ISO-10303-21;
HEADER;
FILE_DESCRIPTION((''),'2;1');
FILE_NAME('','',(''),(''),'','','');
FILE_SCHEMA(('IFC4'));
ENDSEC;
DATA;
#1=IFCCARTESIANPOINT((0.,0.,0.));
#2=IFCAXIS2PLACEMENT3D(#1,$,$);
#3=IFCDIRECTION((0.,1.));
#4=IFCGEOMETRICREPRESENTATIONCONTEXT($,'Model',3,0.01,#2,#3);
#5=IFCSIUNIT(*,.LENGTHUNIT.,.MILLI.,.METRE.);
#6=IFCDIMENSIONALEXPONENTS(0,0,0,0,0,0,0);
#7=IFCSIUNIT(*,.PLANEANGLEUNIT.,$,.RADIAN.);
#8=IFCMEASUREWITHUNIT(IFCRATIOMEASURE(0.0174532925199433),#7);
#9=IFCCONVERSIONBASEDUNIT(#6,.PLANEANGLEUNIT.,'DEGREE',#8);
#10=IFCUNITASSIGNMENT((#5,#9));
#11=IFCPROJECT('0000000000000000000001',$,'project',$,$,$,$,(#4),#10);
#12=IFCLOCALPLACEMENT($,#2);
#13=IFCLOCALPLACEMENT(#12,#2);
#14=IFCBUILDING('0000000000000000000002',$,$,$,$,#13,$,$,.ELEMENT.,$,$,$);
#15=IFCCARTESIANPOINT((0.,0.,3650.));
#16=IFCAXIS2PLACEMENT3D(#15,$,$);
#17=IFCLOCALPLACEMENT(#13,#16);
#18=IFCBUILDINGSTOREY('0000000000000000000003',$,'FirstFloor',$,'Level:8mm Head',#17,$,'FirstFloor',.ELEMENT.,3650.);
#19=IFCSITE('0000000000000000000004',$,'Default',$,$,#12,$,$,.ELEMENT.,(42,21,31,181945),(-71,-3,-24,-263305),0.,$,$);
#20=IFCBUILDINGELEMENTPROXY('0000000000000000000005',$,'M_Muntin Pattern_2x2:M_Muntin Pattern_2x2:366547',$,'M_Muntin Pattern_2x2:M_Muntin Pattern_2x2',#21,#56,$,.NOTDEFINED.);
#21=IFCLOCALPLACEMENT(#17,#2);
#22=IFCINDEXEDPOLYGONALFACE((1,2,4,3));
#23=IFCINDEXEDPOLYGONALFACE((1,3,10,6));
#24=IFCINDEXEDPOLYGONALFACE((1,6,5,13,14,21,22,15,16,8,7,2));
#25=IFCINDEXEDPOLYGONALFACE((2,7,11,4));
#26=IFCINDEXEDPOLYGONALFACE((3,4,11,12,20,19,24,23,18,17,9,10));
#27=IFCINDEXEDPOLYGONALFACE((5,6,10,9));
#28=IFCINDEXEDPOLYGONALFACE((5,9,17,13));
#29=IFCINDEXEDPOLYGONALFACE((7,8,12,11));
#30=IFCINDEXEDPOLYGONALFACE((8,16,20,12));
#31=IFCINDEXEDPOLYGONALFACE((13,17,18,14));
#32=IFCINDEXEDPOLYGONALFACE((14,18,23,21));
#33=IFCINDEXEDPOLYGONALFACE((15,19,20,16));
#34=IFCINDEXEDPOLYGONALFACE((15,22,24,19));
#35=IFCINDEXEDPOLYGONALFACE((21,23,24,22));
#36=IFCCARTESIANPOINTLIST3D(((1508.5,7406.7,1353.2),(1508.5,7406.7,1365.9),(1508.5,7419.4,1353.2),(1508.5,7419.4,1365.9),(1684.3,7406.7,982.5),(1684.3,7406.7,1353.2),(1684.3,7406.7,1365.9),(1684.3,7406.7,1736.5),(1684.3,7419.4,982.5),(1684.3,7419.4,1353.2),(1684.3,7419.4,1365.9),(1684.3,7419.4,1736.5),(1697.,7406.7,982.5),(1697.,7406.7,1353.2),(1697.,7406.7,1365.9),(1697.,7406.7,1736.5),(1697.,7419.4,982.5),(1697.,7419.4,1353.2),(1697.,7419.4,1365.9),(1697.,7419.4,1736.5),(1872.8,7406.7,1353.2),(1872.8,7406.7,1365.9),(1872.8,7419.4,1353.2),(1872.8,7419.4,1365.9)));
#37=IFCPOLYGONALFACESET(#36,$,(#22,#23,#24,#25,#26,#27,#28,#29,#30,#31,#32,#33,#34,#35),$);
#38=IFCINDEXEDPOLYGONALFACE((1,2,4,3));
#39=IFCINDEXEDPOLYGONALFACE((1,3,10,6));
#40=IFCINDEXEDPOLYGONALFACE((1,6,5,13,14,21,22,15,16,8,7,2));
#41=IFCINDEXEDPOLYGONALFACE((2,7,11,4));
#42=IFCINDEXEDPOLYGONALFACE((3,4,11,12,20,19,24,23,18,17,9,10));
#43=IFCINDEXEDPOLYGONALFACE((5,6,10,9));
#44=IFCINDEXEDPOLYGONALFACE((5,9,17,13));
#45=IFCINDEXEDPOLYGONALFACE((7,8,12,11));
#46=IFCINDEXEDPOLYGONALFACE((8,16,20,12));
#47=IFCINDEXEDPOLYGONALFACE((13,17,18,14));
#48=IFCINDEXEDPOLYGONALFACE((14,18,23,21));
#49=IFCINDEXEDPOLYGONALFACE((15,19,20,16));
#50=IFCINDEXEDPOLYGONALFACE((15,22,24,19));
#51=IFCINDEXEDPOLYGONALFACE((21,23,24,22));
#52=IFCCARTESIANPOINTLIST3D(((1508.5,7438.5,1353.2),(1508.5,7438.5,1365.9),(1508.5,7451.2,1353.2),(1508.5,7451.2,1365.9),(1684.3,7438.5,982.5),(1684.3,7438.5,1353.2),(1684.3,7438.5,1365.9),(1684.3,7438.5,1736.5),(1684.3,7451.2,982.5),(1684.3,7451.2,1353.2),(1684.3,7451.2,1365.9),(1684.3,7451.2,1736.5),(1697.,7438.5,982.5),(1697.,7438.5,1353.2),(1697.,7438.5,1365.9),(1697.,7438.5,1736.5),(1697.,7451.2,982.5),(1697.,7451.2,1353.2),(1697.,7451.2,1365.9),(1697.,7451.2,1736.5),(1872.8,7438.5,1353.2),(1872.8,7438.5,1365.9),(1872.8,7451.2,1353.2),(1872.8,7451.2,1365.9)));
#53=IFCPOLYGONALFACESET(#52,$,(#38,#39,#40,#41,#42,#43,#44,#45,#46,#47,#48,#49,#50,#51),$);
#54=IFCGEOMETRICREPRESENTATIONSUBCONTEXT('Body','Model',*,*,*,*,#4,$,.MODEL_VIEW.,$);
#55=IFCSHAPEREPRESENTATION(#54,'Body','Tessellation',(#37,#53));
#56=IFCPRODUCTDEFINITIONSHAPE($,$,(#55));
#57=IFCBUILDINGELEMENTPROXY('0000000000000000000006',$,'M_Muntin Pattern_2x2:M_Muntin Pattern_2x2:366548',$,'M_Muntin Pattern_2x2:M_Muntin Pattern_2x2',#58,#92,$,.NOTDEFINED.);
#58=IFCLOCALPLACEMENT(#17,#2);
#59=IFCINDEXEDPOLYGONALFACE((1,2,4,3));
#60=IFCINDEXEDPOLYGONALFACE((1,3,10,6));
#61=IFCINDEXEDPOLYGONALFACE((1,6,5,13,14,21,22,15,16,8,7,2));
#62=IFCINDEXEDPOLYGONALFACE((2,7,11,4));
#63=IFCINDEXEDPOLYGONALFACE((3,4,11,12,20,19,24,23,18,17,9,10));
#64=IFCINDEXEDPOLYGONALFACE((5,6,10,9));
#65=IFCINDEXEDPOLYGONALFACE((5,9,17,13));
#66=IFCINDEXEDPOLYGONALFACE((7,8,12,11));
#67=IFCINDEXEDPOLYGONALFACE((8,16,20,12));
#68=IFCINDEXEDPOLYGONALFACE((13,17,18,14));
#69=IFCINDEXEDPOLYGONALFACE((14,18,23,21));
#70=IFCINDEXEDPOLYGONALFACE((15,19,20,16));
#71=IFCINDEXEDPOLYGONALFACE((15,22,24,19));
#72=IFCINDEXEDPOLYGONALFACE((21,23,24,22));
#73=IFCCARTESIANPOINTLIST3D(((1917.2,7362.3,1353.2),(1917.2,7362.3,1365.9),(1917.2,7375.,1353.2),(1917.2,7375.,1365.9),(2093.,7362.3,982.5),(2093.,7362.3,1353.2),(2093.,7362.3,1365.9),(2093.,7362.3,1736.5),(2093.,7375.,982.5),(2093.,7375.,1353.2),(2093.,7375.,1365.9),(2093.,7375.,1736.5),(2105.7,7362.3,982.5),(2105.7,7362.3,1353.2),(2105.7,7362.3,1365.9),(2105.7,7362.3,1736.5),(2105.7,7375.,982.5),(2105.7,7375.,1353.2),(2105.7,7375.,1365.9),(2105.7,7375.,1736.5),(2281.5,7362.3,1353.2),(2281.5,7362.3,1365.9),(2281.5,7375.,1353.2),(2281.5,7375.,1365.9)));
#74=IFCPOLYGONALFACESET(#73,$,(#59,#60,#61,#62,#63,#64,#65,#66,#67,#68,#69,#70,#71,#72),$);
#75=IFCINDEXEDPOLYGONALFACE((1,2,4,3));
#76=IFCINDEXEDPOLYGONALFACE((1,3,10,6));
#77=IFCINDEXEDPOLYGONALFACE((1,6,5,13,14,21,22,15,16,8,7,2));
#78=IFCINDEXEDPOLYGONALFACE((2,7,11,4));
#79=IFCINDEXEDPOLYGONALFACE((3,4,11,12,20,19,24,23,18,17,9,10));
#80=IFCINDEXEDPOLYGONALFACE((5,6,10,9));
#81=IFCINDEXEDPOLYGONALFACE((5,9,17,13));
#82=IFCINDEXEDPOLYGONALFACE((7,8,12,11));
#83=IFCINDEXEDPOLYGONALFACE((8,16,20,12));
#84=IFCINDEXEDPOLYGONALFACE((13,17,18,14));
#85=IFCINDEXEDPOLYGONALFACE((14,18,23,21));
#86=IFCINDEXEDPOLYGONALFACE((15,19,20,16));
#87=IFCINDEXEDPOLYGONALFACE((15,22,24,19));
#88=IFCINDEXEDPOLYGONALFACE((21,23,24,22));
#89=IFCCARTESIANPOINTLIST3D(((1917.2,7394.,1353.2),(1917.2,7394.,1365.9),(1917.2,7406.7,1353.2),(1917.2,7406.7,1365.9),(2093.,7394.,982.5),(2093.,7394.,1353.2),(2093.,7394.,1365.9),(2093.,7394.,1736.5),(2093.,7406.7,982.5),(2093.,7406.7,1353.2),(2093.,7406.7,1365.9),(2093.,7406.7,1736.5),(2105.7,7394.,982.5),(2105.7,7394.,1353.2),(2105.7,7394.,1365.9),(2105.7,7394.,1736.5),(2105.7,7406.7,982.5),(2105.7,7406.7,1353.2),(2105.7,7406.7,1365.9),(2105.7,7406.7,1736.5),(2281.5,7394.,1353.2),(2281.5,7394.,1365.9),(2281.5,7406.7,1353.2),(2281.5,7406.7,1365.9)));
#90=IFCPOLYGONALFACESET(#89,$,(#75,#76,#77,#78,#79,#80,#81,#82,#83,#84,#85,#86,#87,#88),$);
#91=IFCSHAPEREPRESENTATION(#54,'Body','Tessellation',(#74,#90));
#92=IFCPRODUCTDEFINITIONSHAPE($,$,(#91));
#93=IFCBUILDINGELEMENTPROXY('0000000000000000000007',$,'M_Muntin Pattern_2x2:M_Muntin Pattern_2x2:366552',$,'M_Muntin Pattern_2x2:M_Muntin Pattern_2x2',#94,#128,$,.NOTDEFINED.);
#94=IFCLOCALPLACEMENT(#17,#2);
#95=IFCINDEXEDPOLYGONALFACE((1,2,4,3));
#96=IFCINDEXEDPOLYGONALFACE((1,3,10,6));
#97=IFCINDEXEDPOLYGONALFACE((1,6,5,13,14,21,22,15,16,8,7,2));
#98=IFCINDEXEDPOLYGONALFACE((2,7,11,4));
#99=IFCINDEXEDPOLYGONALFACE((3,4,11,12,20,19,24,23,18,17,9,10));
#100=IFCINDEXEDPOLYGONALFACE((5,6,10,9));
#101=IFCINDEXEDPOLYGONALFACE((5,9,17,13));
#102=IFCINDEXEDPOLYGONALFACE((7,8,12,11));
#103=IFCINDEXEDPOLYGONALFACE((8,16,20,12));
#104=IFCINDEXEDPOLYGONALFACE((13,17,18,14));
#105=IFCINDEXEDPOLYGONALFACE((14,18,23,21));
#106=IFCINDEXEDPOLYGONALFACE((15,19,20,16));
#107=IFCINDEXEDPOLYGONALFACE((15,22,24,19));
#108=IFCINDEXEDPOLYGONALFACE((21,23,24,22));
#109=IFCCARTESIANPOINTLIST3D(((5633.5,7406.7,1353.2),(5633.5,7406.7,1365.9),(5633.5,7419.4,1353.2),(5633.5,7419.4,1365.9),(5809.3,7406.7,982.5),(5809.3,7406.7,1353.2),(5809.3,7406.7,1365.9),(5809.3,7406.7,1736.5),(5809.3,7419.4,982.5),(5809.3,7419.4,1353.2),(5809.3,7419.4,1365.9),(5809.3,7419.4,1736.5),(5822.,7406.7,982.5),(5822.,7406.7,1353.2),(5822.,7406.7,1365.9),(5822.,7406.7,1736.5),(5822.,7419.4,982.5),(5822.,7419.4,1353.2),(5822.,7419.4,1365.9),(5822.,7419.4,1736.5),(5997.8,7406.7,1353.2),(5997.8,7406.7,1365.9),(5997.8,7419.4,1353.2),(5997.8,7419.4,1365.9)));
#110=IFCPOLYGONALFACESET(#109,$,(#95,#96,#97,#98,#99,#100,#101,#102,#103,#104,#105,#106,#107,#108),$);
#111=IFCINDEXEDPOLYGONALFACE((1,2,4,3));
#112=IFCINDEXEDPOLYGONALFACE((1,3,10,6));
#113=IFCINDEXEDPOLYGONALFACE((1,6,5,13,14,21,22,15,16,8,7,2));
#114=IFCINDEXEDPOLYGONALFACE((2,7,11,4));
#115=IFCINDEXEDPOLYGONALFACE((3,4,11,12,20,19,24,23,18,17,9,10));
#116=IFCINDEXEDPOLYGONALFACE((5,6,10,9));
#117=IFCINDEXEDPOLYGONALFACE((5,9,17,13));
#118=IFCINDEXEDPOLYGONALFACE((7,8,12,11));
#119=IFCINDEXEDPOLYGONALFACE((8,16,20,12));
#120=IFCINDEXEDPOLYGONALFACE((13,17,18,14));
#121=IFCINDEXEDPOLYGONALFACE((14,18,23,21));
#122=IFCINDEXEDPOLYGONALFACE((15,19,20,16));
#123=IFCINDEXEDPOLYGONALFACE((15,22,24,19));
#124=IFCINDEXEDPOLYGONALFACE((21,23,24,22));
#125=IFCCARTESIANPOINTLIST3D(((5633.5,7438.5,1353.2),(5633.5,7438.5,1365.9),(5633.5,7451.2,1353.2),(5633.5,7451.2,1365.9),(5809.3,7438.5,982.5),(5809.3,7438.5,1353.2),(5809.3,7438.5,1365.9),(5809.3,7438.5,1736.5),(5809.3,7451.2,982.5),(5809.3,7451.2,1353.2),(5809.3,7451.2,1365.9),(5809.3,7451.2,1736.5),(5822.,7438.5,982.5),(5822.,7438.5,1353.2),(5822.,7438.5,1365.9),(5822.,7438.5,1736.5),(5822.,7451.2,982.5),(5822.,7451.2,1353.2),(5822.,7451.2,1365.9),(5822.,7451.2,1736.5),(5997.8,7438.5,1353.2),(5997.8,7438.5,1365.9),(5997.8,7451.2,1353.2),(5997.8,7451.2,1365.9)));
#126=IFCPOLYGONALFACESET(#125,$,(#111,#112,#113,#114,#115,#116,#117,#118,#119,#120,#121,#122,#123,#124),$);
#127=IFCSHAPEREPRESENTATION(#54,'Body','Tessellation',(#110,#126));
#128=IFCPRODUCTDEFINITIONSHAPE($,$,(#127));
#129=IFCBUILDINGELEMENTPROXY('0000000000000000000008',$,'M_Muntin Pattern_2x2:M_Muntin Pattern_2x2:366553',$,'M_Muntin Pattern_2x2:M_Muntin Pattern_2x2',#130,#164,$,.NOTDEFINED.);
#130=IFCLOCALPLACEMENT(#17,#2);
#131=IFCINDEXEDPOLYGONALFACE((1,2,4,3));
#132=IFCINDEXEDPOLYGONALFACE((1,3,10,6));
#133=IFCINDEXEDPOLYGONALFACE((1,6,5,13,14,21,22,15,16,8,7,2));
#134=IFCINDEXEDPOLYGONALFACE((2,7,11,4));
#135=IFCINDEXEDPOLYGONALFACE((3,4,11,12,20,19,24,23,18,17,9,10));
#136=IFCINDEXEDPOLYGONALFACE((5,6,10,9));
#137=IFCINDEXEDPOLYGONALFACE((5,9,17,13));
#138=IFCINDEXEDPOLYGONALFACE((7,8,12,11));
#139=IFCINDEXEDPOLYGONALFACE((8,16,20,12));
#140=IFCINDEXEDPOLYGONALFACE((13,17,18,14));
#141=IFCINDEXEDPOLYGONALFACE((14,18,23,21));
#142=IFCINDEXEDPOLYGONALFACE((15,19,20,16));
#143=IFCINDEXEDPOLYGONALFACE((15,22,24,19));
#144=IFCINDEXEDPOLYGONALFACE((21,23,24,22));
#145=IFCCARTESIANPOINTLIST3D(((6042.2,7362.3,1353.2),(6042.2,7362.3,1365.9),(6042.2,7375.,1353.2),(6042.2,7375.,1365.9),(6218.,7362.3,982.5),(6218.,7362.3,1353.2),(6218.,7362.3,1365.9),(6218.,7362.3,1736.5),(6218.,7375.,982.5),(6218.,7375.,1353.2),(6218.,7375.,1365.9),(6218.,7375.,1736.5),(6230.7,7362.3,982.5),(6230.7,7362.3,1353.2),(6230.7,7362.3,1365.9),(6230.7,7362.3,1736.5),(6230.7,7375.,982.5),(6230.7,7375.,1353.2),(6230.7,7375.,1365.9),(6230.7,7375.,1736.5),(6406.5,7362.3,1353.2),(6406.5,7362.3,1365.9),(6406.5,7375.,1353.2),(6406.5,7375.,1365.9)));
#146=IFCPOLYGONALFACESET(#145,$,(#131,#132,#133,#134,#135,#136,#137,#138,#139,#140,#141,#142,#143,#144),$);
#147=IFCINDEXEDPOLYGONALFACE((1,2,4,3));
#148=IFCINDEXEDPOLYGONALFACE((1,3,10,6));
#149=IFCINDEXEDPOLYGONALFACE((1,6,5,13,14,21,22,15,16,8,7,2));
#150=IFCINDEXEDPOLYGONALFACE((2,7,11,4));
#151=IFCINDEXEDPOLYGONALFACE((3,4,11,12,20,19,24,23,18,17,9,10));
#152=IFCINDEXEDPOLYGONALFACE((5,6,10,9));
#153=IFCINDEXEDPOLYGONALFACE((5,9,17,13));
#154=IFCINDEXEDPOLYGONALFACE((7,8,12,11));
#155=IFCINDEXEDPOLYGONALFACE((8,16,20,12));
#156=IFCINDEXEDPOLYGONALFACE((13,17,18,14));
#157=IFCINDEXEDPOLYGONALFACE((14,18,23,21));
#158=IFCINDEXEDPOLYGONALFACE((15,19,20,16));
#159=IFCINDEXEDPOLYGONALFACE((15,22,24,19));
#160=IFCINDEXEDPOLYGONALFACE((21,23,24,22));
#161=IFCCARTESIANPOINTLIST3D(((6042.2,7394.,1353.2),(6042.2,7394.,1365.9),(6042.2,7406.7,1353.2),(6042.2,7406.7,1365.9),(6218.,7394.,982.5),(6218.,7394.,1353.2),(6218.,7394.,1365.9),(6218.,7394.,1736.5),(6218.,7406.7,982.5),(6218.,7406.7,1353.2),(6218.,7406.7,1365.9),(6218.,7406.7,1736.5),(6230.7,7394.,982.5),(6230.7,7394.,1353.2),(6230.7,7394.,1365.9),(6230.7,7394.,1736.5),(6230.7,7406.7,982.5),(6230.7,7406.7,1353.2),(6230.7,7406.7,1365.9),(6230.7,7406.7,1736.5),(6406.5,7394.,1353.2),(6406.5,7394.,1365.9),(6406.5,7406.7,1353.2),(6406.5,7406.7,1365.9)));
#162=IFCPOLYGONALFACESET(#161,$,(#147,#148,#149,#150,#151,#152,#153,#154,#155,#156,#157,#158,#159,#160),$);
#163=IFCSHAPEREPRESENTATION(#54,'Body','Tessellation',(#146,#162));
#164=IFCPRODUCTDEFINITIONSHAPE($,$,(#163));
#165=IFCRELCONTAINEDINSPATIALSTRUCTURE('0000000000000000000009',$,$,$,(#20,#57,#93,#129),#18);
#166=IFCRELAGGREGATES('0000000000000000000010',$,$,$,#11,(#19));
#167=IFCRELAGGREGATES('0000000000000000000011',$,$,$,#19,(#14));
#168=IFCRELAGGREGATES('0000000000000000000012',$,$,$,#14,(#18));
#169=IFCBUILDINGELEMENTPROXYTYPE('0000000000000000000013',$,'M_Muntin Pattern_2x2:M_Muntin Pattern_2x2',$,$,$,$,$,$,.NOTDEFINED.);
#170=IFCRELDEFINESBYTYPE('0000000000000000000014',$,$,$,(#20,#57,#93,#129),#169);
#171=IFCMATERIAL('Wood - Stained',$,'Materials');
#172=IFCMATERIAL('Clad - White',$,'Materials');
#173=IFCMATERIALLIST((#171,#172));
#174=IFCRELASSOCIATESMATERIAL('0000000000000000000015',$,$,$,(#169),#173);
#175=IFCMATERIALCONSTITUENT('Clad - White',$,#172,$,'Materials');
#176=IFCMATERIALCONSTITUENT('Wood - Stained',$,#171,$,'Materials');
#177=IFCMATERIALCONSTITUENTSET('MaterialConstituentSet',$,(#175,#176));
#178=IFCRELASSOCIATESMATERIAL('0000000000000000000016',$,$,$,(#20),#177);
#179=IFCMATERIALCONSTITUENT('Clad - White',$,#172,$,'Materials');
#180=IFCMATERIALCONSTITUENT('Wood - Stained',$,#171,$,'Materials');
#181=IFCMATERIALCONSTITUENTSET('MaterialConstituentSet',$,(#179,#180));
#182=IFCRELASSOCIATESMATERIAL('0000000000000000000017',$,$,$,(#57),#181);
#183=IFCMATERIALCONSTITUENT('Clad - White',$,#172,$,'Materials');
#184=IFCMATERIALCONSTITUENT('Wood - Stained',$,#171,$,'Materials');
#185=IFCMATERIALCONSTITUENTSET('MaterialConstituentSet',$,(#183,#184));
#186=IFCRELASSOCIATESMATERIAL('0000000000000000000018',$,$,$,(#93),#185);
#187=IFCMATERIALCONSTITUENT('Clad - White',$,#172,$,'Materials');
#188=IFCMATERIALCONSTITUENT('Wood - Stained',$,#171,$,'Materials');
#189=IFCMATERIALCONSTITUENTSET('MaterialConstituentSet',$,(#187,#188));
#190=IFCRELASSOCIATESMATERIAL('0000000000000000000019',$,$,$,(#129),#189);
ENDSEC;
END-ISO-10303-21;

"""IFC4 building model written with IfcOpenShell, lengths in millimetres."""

from ifc_helpers import new_model, entity, si_unit, converted_unit, direction, frame, origin, place, context, subcontext, project, spatial, polyline, outline, extrude, source, transform, mapped, material, material_list, constituent, constituent_set, type_object, type_shapes, element, save


model = new_model("IFC4")

# Units and contexts
model_context = context("Model", 3, precision=0.01, world=origin(), true_north=direction((0.0, 1.0)))
body_context = subcontext(model_context, "Body", "Model", "MODEL_VIEW")
ifc_project = project(units=[si_unit("LENGTHUNIT", "METRE", prefix="MILLI"), converted_unit("PLANEANGLEUNIT", "DEGREE", entity("IfcRatioMeasure", 0.0174532925199433), si_unit("PLANEANGLEUNIT", "RADIAN"), dimensions=[0, 0, 0, 0, 0, 0, 0])], contexts=[model_context])

# Site, building, storey
site_placement = place(None, origin())
site = spatial("IfcSite", under=ifc_project, at=site_placement, Name="Default", CompositionType="ELEMENT", RefLatitude=(42, 21, 31, 181945), RefLongitude=(-71, -3, -24, -263305), RefElevation=0.0)
building_placement = place(site_placement, origin())
building = spatial("IfcBuilding", under=site, at=building_placement, CompositionType="ELEMENT")
storey_placement = place(building_placement, frame((0.0, 0.0, 3650.0)))
storey = spatial("IfcBuildingStorey", under=building, at=storey_placement, Name="FirstFloor", ObjectType="Level:8mm Head", LongName="FirstFloor", CompositionType="ELEMENT", Elevation=3650.0)

# Shared definitions
ifc_material_1 = material(Name="Clad - White", Category="Materials")
ifc_material_2 = material(Name="Wood - Stained", Category="Materials")

# Building element proxies
ifc_constituent_1 = constituent(ifc_material_1, Name="Clad - White", Category="Materials")
ifc_constituent_2 = constituent(ifc_material_2, Name="Wood - Stained", Category="Materials")
ifc_constituent_set_1 = constituent_set(constituents=[ifc_constituent_1, ifc_constituent_2], Name="MaterialConstituentSet")
ifc_material_list_1 = material_list([ifc_material_2, ifc_material_1])
building_element_proxy_type_1 = type_object("IfcBuildingElementProxyType", Name="M_Muntin Pattern_2x2:M_Muntin Pattern_2x2", PredefinedType="NOTDEFINED", material=ifc_material_list_1)
shared_shape_1 = source(origin(), body_context, "Body", "SweptSolid", [
    extrude(outline(polyline([(6.4, -6.4), (377.0, -6.4), (377.0, 6.3), (6.4, 6.3), (6.4, 182.1), (-6.3, 182.1), (-6.3, 6.3), (-377.0, 6.3), (-377.0, -6.4), (-6.3, -6.4), (-6.3, -182.1), (6.4, -182.1), (6.4, -6.4)])), frame((0.0, 9.5, 377.0), z_axis=(0.0, 1.0, 0.0), x_axis=(0.0, 0.0, 1.0)), (0.0, 0.0, 1.0), 12.7),
    extrude(outline(polyline([(6.4, -6.4), (377.0, -6.4), (377.0, 6.3), (6.4, 6.3), (6.4, 182.1), (-6.3, 182.1), (-6.3, 6.3), (-377.0, 6.3), (-377.0, -6.4), (-6.3, -6.4), (-6.3, -182.1), (6.4, -182.1), (6.4, -6.4)])), frame((0.0, -22.2, 377.0), z_axis=(0.0, 1.0, 0.0), x_axis=(0.0, 0.0, 1.0)), (0.0, 0.0, 1.0), 12.7),
])
type_shapes(building_element_proxy_type_1, [shared_shape_1])
proxy_1_placement = place(storey_placement, frame((1690.6, 7429.0, 982.5), z_axis=(0.0, 0.0, 1.0), x_axis=(-1.0, 0.0, 0.0)))
element("IfcBuildingElementProxy", 1, at=proxy_1_placement, inside=storey, type_object=building_element_proxy_type_1, material=ifc_constituent_set_1, Name="M_Muntin Pattern_2x2:M_Muntin Pattern_2x2:366547", ObjectType="M_Muntin Pattern_2x2:M_Muntin Pattern_2x2", PredefinedType="NOTDEFINED", context=body_context, shape_type="MappedRepresentation", body=[
    mapped(shared_shape_1, transform((0.0, 0.0, 0.0), scale=1.0)),
])
ifc_constituent_3 = constituent(ifc_material_1, Name="Clad - White", Category="Materials")
ifc_constituent_4 = constituent(ifc_material_2, Name="Wood - Stained", Category="Materials")
ifc_constituent_set_2 = constituent_set(constituents=[ifc_constituent_3, ifc_constituent_4], Name="MaterialConstituentSet")
proxy_2_placement = place(storey_placement, frame((2099.4, 7384.5, 982.5), z_axis=(0.0, 0.0, 1.0), x_axis=(-1.0, 0.0, 0.0)))
element("IfcBuildingElementProxy", 2, at=proxy_2_placement, inside=storey, type_object=building_element_proxy_type_1, material=ifc_constituent_set_2, Name="M_Muntin Pattern_2x2:M_Muntin Pattern_2x2:366548", ObjectType="M_Muntin Pattern_2x2:M_Muntin Pattern_2x2", PredefinedType="NOTDEFINED", context=body_context, shape_type="MappedRepresentation", body=[
    mapped(shared_shape_1, transform((0.0, 0.0, 0.0), scale=1.0)),
])
ifc_constituent_5 = constituent(ifc_material_1, Name="Clad - White", Category="Materials")
ifc_constituent_6 = constituent(ifc_material_2, Name="Wood - Stained", Category="Materials")
ifc_constituent_set_3 = constituent_set(constituents=[ifc_constituent_5, ifc_constituent_6], Name="MaterialConstituentSet")
proxy_3_placement = place(storey_placement, frame((5815.6, 7429.0, 982.5), z_axis=(0.0, 0.0, 1.0), x_axis=(-1.0, 0.0, 0.0)))
element("IfcBuildingElementProxy", 3, at=proxy_3_placement, inside=storey, type_object=building_element_proxy_type_1, material=ifc_constituent_set_3, Name="M_Muntin Pattern_2x2:M_Muntin Pattern_2x2:366552", ObjectType="M_Muntin Pattern_2x2:M_Muntin Pattern_2x2", PredefinedType="NOTDEFINED", context=body_context, shape_type="MappedRepresentation", body=[
    mapped(shared_shape_1, transform((0.0, 0.0, 0.0), scale=1.0)),
])
ifc_constituent_7 = constituent(ifc_material_1, Name="Clad - White", Category="Materials")
ifc_constituent_8 = constituent(ifc_material_2, Name="Wood - Stained", Category="Materials")
ifc_constituent_set_4 = constituent_set(constituents=[ifc_constituent_7, ifc_constituent_8], Name="MaterialConstituentSet")
proxy_4_placement = place(storey_placement, frame((6224.4, 7384.5, 982.5), z_axis=(0.0, 0.0, 1.0), x_axis=(-1.0, 0.0, 0.0)))
element("IfcBuildingElementProxy", 4, at=proxy_4_placement, inside=storey, type_object=building_element_proxy_type_1, material=ifc_constituent_set_4, Name="M_Muntin Pattern_2x2:M_Muntin Pattern_2x2:366553", ObjectType="M_Muntin Pattern_2x2:M_Muntin Pattern_2x2", PredefinedType="NOTDEFINED", context=body_context, shape_type="MappedRepresentation", body=[
    mapped(shared_shape_1, transform((0.0, 0.0, 0.0), scale=1.0)),
])

save(model, "model.ifc")
